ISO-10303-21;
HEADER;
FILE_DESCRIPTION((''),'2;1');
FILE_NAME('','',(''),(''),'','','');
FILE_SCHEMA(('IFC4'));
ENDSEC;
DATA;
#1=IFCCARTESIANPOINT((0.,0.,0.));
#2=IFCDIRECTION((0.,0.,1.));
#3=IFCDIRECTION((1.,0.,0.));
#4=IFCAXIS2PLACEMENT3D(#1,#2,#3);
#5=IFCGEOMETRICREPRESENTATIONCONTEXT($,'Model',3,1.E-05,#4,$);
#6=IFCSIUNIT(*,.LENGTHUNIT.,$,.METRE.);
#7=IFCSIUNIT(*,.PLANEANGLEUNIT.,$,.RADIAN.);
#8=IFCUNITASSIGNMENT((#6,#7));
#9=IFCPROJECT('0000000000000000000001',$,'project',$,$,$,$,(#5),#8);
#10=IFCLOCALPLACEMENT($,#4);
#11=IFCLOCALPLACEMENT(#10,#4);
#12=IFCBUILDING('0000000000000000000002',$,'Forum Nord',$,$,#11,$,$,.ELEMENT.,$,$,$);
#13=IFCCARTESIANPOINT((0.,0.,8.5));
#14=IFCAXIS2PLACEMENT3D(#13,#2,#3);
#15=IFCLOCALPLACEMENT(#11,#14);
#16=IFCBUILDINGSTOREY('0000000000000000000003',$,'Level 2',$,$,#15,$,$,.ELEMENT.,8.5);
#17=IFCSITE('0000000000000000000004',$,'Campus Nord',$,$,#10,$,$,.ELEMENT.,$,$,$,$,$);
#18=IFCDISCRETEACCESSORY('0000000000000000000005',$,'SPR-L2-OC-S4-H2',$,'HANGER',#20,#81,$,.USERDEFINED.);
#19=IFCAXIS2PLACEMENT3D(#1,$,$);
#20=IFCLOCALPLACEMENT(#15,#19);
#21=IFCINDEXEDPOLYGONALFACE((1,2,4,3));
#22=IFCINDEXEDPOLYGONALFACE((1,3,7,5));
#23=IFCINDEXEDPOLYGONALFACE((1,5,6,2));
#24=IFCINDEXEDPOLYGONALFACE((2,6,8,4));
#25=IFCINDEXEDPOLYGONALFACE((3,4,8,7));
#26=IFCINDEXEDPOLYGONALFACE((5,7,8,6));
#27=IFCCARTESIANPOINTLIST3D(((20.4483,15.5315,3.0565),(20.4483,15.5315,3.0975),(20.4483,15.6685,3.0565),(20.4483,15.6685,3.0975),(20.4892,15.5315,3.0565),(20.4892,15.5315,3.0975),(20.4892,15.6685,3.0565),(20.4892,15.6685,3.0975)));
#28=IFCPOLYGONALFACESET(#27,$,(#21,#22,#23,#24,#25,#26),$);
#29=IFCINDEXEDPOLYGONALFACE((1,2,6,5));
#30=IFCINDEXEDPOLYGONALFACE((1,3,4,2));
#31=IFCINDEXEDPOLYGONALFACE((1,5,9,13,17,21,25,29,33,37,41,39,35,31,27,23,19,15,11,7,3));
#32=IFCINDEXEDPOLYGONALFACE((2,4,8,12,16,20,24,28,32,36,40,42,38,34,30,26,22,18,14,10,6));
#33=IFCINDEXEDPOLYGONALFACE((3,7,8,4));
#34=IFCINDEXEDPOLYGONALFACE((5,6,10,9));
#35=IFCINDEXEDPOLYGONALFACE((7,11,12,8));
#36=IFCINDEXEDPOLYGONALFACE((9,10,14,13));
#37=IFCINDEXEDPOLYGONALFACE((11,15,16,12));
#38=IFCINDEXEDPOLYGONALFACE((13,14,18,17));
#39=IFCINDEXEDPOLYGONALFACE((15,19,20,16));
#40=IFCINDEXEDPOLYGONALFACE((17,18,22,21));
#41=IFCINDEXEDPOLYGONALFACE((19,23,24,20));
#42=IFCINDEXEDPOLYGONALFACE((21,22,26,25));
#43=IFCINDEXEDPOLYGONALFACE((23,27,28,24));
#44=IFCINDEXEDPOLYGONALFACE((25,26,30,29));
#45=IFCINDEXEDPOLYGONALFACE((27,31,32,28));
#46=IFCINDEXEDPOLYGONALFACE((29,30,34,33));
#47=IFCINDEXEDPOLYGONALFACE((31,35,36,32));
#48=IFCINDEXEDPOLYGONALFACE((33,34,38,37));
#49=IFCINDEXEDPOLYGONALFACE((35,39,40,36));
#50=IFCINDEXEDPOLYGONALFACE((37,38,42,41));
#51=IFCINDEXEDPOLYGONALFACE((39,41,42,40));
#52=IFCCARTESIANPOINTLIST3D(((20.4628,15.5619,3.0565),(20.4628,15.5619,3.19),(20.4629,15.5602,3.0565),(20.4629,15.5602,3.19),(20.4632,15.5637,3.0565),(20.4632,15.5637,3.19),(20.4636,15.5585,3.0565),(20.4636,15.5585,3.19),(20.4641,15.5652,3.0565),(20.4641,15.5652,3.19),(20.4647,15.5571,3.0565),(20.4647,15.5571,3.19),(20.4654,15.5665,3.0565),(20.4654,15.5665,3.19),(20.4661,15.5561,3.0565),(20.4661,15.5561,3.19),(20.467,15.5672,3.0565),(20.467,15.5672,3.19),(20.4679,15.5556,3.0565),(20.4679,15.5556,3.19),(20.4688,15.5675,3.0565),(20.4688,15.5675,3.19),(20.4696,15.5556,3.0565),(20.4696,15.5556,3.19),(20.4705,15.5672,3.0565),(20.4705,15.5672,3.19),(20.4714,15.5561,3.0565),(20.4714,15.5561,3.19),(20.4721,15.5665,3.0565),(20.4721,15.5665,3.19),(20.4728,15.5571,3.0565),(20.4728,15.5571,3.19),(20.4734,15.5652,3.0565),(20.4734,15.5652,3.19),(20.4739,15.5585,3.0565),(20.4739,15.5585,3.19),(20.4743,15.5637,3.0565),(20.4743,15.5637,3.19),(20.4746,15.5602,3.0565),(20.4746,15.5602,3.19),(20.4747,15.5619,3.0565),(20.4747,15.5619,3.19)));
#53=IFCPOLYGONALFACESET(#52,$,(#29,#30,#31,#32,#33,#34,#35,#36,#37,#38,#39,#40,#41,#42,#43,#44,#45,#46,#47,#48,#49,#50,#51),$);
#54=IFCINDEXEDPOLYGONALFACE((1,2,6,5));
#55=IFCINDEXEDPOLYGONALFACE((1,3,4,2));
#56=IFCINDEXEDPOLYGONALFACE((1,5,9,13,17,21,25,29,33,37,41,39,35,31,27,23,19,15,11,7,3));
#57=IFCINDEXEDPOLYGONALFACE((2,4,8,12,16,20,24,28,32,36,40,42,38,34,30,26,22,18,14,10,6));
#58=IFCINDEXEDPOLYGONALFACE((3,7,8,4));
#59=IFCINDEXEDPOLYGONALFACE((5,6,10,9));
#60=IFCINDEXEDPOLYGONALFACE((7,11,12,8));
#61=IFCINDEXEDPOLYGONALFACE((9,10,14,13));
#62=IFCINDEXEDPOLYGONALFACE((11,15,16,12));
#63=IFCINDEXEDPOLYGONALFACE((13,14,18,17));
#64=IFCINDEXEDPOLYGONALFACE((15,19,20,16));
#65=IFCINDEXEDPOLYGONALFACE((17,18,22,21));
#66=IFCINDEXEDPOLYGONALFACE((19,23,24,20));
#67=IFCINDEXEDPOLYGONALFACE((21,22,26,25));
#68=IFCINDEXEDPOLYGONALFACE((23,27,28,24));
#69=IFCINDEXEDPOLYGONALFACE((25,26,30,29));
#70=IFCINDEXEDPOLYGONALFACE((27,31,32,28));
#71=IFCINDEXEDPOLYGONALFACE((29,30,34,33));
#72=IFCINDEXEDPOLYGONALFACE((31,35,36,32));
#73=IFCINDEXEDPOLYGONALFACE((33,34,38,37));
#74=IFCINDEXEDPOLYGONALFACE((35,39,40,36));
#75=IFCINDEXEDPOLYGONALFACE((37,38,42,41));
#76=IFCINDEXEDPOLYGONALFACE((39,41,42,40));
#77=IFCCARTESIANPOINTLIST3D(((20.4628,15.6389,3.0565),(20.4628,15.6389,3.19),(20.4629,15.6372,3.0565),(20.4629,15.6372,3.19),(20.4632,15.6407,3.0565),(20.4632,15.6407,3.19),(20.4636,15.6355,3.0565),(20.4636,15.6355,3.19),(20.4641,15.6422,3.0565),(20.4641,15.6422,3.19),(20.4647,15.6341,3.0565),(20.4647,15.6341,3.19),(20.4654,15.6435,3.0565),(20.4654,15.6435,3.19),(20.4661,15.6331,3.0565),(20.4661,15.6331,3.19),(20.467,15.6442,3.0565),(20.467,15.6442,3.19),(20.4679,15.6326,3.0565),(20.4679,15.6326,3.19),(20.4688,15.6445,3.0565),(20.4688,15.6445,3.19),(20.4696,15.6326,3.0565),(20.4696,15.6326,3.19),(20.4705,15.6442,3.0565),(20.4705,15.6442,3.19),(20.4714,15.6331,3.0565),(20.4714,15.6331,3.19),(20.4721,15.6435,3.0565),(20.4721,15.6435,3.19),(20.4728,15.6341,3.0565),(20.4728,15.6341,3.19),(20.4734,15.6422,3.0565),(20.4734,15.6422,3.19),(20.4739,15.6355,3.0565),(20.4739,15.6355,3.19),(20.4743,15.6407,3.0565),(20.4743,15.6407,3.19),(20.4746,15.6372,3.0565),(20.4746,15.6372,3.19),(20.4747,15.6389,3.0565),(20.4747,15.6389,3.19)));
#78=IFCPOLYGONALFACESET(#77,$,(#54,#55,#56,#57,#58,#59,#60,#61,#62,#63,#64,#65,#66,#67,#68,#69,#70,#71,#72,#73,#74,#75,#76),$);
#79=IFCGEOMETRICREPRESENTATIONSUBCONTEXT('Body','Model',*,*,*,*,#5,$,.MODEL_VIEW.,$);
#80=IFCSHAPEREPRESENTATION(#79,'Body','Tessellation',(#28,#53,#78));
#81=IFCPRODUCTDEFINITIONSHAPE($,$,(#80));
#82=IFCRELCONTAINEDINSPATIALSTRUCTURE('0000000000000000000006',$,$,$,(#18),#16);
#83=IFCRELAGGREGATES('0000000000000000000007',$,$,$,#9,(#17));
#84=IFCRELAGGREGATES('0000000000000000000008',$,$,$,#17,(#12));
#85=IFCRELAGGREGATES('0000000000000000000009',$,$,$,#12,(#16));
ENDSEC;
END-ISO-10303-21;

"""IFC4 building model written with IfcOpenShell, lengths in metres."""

from ifc_helpers import new_model, si_unit, frame, frame_2d, origin_with_axes, origin_2d_with_axis, place, context, subcontext, project, spatial, rectangle, circle, extrude, element, save


model = new_model("IFC4")

# Units and contexts
model_context = context("Model", 3, precision=1e-05, world=origin_with_axes())
body_context = subcontext(model_context, "Body", "Model", "MODEL_VIEW")
ifc_project = project(units=[si_unit("LENGTHUNIT", "METRE"), si_unit("PLANEANGLEUNIT", "RADIAN")], contexts=[model_context])

# Site, building, storey
site_placement = place(None, origin_with_axes())
site = spatial("IfcSite", under=ifc_project, at=site_placement, Name="Campus Nord", CompositionType="ELEMENT")
building_placement = place(site_placement, origin_with_axes())
building = spatial("IfcBuilding", under=site, at=building_placement, Name="Forum Nord", CompositionType="ELEMENT")
storey_placement = place(building_placement, frame((0.0, 0.0, 8.5), z_axis=(0.0, 0.0, 1.0), x_axis=(1.0, 0.0, 0.0)))
storey = spatial("IfcBuildingStorey", under=building, at=storey_placement, Name="Level 2", CompositionType="ELEMENT", Elevation=8.5)

# Discrete accessory
for number, where, z_axis, x_axis, name in (
    (1, (20.4688, 15.6, 3.0975), (0.0, 0.0, 1.0), (0.0, 1.0, 0.0), "SPR-L2-OC-S4-H2"),
):
    element("IfcDiscreteAccessory", number, at=place(storey_placement, frame(where, z_axis=z_axis, x_axis=x_axis)), inside=storey, Name=name, ObjectType="HANGER", PredefinedType="USERDEFINED", context=body_context, shape_type="SweptSolid", body=[
        extrude(rectangle(XDim=0.137, YDim=0.041, at=origin_2d_with_axis()), frame((0.0, 0.0, -0.041), z_axis=(0.0, 0.0, 1.0), x_axis=(1.0, 0.0, 0.0)), (0.0, 0.0, 1.0), 0.041),
        extrude(circle(Radius=0.006, at=frame_2d((-0.0385, 0.0), x_axis=(1.0, 0.0))), frame((0.0, 0.0, -0.041), z_axis=(0.0, 0.0, 1.0), x_axis=(1.0, 0.0, 0.0)), (0.0, 0.0, 1.0), 0.1335),
        extrude(circle(Radius=0.006, at=frame_2d((0.0385, 0.0), x_axis=(1.0, 0.0))), frame((0.0, 0.0, -0.041), z_axis=(0.0, 0.0, 1.0), x_axis=(1.0, 0.0, 0.0)), (0.0, 0.0, 1.0), 0.1335),
    ])

save(model, "model.ifc")
